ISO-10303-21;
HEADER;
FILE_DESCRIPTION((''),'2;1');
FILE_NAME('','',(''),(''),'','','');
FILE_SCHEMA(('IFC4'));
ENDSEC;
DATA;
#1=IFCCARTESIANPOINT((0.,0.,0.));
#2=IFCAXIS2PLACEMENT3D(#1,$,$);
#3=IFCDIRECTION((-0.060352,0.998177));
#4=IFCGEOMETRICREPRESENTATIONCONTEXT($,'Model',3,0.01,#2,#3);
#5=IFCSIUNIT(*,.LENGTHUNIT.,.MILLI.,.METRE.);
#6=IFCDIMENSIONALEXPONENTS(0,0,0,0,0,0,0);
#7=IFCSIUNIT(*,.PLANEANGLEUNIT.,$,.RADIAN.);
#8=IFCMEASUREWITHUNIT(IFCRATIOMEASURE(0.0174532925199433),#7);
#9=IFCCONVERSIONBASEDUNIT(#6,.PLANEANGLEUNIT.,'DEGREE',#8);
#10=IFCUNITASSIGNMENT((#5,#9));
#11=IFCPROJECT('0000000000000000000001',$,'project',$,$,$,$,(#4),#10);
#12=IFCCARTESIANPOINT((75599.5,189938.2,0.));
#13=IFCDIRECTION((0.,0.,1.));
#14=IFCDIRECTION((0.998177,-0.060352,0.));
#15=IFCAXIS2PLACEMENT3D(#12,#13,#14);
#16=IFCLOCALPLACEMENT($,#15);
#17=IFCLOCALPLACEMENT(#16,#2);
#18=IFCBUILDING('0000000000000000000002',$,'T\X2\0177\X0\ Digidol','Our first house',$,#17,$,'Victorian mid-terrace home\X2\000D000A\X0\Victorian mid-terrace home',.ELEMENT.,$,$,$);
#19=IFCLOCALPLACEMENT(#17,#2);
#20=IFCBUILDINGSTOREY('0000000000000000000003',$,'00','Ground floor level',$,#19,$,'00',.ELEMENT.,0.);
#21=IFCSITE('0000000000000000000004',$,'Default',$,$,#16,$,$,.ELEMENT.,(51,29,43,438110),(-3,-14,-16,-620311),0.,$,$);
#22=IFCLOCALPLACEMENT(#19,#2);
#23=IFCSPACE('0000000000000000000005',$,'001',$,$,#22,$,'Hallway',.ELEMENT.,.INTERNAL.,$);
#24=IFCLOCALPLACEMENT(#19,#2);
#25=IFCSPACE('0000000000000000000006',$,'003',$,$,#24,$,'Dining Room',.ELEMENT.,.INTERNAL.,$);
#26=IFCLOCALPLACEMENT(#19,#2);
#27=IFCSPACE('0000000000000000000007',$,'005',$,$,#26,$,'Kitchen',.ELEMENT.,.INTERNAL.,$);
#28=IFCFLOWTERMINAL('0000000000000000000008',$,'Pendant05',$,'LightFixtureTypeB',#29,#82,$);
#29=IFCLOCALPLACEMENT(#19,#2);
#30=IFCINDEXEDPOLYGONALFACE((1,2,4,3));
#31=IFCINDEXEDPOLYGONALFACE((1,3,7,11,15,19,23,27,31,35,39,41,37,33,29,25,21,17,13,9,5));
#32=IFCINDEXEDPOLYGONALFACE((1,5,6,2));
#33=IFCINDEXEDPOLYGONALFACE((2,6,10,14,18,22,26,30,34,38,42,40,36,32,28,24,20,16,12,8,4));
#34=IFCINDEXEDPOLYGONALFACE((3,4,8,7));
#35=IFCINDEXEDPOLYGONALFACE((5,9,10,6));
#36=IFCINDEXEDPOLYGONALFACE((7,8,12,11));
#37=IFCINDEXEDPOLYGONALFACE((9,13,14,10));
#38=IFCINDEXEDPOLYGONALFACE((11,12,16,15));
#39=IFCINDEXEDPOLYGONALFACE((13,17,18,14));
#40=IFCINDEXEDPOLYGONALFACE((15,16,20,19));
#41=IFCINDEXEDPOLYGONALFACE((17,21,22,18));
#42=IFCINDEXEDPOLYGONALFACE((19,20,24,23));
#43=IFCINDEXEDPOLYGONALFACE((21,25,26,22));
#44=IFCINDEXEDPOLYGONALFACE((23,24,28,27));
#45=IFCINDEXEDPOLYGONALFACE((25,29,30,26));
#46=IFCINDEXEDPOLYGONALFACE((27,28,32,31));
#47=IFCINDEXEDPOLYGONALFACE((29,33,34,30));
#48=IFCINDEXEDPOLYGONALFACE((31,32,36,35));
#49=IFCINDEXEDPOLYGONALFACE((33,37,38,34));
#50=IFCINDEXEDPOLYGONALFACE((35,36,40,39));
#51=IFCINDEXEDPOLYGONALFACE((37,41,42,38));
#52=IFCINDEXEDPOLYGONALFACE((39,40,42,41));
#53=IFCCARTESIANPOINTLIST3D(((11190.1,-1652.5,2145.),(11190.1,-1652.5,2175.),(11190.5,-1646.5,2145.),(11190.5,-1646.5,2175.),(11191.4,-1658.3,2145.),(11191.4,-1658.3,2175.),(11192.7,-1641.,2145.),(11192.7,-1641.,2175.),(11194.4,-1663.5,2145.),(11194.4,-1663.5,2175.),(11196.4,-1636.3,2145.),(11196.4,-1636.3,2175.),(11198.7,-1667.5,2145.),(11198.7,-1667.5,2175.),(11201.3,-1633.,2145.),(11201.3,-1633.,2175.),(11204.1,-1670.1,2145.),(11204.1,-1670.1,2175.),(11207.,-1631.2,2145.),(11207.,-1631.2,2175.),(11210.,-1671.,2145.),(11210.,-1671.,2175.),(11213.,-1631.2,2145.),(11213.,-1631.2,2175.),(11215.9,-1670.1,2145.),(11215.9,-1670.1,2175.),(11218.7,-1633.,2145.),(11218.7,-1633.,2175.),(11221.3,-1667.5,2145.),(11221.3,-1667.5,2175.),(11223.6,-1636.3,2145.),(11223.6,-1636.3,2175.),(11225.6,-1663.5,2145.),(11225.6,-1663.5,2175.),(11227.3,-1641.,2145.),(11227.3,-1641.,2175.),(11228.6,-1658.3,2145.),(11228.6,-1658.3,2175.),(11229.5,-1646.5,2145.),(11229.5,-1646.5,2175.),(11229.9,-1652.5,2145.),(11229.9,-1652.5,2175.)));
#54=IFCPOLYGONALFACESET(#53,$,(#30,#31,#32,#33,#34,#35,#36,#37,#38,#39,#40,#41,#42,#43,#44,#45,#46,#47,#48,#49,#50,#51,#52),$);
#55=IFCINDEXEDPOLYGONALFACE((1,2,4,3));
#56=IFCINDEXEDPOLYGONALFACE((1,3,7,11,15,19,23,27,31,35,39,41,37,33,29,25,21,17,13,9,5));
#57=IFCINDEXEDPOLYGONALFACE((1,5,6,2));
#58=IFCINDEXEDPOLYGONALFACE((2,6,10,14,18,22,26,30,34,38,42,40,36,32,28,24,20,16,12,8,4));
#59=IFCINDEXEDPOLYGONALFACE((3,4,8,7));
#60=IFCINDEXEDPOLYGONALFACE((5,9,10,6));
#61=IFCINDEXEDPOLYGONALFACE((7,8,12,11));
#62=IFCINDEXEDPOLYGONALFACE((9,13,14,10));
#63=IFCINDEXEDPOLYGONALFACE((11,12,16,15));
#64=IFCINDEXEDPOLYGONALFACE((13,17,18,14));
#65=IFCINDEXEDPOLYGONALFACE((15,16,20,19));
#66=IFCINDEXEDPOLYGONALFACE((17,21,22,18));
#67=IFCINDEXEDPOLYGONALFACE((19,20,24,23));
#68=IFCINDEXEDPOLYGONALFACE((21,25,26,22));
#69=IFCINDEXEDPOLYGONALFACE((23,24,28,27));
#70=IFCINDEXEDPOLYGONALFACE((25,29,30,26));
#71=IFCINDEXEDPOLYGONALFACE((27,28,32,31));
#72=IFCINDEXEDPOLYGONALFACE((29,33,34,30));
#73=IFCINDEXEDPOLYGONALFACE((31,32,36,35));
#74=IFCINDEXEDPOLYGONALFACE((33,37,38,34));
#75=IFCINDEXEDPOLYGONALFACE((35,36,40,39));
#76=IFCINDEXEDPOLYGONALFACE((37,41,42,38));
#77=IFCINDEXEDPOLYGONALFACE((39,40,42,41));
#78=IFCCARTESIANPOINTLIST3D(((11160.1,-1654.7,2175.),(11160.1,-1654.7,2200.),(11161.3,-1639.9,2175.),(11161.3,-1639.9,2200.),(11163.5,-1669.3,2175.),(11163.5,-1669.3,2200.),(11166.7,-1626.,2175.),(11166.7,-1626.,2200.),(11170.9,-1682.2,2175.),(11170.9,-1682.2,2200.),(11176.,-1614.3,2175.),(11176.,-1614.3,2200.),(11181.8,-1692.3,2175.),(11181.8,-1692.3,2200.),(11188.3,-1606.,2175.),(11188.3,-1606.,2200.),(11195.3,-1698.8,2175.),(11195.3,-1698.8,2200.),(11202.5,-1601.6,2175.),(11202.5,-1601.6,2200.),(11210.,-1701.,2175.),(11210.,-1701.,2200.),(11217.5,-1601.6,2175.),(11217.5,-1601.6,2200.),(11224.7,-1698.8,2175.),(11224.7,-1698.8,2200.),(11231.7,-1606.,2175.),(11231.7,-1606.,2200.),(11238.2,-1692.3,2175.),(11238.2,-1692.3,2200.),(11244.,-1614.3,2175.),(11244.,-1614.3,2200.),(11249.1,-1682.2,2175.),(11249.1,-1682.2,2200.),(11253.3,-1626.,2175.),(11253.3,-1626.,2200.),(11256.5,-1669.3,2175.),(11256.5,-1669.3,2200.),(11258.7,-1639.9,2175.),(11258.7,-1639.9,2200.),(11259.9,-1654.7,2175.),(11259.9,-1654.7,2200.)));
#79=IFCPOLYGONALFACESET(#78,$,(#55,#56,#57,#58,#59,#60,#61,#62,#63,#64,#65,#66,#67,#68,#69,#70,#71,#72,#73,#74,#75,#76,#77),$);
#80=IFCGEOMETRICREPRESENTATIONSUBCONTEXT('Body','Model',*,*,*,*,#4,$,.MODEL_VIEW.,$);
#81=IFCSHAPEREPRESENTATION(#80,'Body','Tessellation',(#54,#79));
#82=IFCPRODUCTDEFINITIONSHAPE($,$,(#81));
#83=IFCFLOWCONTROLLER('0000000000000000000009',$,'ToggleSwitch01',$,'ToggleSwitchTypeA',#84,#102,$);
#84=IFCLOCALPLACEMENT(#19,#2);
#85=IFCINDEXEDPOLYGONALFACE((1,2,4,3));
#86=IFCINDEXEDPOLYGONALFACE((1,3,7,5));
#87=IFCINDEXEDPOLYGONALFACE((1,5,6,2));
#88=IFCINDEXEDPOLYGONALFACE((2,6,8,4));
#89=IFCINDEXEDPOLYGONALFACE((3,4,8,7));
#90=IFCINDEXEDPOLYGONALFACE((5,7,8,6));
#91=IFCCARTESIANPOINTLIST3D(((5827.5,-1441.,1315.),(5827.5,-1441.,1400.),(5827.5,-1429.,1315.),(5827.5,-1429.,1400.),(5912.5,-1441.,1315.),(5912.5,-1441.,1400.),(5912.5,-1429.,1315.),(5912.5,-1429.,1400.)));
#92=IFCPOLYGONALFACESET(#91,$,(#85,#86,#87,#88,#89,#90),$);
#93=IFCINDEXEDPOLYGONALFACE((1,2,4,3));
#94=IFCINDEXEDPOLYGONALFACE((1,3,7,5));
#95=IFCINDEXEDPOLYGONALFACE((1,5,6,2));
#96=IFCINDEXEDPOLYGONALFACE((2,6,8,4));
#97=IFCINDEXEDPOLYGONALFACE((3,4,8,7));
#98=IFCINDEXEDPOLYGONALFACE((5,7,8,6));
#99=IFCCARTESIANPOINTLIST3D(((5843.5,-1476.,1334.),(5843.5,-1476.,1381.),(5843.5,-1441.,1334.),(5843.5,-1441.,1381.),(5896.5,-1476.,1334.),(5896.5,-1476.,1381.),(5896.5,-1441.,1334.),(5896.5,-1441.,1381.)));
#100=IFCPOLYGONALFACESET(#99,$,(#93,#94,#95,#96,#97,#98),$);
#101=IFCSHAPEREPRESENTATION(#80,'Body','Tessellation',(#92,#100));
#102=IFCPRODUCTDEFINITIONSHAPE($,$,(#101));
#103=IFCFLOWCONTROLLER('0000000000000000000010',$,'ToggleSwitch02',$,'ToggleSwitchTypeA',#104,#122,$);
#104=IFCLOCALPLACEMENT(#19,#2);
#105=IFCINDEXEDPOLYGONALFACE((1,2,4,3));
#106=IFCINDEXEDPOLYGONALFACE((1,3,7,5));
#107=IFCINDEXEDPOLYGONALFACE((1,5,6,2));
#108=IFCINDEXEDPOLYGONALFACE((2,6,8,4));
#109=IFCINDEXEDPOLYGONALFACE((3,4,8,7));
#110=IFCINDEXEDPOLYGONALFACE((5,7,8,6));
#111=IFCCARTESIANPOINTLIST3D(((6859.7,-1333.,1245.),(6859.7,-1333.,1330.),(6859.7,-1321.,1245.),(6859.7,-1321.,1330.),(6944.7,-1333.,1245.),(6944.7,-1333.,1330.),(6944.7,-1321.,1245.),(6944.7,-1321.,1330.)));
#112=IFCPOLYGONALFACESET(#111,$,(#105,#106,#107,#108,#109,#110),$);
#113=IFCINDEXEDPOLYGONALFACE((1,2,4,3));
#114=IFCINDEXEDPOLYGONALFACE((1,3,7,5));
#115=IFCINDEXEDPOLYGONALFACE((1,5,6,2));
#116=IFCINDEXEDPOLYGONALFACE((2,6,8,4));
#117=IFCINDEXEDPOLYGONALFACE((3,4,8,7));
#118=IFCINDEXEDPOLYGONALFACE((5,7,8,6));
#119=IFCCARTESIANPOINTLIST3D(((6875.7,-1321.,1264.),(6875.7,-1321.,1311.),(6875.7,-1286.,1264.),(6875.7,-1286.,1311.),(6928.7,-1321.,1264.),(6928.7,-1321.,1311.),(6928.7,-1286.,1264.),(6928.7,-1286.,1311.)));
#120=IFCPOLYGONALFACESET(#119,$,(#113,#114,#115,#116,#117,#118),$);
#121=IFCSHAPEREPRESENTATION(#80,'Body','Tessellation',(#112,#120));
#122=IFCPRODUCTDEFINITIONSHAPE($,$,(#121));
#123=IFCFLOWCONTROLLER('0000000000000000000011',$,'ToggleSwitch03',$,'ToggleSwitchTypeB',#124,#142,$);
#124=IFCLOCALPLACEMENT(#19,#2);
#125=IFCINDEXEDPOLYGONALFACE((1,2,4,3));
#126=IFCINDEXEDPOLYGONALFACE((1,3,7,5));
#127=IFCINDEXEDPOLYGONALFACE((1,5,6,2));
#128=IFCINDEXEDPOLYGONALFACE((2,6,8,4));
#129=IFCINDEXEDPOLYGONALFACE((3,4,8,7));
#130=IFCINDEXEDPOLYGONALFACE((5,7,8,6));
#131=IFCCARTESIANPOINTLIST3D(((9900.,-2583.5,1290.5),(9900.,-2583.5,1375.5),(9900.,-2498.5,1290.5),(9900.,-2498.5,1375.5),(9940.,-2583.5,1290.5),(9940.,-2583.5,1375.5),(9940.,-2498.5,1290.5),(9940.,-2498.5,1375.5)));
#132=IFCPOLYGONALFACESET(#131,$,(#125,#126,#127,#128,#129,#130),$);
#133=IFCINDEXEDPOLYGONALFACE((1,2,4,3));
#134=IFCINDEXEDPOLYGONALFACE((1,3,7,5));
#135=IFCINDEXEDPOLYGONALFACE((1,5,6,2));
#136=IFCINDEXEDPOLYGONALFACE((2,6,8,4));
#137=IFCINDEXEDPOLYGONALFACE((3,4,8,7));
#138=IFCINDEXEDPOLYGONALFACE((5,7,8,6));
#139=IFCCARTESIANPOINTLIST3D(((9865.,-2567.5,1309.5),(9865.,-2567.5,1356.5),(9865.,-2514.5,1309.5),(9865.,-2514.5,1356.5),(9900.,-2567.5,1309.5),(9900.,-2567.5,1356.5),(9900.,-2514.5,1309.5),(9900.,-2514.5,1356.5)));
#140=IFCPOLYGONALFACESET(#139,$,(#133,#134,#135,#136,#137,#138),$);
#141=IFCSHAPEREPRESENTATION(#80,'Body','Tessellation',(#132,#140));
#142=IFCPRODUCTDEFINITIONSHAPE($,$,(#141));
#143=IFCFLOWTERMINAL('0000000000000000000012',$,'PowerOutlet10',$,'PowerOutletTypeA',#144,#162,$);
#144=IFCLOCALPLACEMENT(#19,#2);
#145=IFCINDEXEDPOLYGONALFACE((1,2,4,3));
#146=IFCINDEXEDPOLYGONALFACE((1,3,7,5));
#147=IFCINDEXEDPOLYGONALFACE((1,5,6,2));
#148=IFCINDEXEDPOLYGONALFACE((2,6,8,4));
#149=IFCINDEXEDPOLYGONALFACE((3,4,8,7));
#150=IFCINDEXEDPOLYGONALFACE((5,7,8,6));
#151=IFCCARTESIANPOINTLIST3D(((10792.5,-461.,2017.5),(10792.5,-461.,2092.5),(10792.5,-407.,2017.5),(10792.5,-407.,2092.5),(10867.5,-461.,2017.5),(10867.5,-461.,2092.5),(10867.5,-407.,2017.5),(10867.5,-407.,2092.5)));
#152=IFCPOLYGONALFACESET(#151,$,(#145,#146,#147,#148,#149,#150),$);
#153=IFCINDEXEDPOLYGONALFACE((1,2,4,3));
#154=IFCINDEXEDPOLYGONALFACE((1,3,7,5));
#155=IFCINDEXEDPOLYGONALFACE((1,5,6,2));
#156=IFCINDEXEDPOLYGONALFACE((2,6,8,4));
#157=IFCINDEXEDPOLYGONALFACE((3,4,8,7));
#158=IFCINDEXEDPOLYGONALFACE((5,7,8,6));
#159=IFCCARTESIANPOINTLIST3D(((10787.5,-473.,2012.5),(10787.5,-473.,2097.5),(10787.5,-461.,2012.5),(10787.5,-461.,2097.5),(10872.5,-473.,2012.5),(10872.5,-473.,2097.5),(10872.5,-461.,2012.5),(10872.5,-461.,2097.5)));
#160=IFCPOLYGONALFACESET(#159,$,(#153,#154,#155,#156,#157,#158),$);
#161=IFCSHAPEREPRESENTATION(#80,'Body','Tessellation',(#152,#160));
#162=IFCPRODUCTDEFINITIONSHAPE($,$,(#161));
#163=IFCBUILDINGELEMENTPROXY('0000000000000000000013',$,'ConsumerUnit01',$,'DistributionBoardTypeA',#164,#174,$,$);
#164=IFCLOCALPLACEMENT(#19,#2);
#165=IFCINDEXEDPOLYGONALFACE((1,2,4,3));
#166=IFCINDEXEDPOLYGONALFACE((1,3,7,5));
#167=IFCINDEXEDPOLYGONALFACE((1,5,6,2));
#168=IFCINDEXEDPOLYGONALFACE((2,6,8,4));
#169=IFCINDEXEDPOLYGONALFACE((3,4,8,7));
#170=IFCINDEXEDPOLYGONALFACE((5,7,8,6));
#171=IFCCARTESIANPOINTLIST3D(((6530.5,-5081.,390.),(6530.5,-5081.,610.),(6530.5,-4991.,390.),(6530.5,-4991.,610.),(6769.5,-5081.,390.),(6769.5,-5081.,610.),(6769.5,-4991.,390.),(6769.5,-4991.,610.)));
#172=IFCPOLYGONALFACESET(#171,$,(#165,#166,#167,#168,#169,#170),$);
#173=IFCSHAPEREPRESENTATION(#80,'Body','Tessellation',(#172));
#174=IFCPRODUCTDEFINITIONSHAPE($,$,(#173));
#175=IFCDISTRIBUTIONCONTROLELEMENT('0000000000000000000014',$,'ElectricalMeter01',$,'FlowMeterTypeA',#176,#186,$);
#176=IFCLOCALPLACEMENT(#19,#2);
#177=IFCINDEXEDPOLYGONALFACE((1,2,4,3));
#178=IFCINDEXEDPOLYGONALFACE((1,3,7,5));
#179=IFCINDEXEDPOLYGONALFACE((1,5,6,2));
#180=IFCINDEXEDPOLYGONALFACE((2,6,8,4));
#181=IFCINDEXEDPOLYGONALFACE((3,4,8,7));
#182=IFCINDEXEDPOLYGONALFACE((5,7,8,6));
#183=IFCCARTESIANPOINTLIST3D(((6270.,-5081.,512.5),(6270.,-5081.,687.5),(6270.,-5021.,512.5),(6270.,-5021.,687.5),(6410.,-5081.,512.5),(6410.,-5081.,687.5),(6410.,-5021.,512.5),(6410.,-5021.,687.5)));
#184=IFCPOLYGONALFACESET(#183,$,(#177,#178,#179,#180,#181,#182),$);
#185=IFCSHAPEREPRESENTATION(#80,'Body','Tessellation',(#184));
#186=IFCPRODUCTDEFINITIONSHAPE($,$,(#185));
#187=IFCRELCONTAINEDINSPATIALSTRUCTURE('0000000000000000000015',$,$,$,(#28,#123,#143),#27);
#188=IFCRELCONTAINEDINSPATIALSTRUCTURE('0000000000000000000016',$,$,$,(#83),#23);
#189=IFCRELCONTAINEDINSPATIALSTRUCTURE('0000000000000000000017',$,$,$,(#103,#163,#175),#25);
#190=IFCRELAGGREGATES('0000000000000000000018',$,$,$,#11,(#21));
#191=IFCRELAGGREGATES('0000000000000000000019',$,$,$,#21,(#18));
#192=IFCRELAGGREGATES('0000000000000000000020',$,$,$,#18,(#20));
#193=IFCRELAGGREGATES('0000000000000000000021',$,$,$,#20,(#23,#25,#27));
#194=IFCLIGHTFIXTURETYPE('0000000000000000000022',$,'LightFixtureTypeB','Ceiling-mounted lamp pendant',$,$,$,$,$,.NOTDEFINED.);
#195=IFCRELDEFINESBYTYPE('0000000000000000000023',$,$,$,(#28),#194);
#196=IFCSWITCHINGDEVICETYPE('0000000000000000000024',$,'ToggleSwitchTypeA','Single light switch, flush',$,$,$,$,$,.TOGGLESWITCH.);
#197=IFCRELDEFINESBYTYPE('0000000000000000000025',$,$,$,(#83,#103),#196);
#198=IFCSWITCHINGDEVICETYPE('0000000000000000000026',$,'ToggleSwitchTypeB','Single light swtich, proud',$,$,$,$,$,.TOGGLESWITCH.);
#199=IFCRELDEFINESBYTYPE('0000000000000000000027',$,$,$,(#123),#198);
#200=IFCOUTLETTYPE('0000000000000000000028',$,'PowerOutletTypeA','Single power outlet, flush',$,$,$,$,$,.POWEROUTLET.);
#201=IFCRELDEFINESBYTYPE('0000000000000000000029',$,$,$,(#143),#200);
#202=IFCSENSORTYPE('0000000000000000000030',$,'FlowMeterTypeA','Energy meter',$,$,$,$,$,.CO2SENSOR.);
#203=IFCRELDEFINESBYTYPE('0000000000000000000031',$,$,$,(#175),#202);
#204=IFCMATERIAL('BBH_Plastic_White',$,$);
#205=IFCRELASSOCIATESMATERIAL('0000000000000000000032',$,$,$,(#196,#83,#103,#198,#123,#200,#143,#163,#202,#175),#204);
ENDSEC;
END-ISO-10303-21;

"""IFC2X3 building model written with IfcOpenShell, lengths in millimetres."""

from ifc_helpers import new_model, entity, si_unit, converted_unit, direction, frame, frame_2d, origin, origin_2d_with_axis, place, context, subcontext, project, spatial, rectangle, circle, extrude, source, transform, mapped, material, type_object, type_shapes, element, save


model = new_model("IFC2X3")

# Units and contexts
model_context = context("Model", 3, precision=0.01, world=origin(), true_north=direction((-0.060352, 0.998177)))
body_context = subcontext(model_context, "Body", "Model", "MODEL_VIEW")
ifc_project = project(units=[si_unit("LENGTHUNIT", "METRE", prefix="MILLI"), converted_unit("PLANEANGLEUNIT", "DEGREE", entity("IfcRatioMeasure", 0.0174532925199433), si_unit("PLANEANGLEUNIT", "RADIAN"), dimensions=[0, 0, 0, 0, 0, 0, 0])], contexts=[model_context])

# Site, building, storey
site_placement = place(None, frame((75599.5, 189938.2, 0.0), z_axis=(0.0, 0.0, 1.0), x_axis=(0.998177, -0.060352, 0.0)))
site = spatial("IfcSite", under=ifc_project, at=site_placement, Name="Default", CompositionType="ELEMENT", RefLatitude=(51, 29, 43, 438110), RefLongitude=(-3, -14, -16, -620311), RefElevation=0.0)
building_placement = place(site_placement, origin())
building = spatial("IfcBuilding", under=site, at=building_placement, Name="Tŷ Digidol", Description="Our first house", LongName="Victorian mid-terrace home\r\nVictorian mid-terrace home", CompositionType="ELEMENT")
storey_placement = place(building_placement, origin())
storey = spatial("IfcBuildingStorey", under=building, at=storey_placement, Name="00", Description="Ground floor level", LongName="00", CompositionType="ELEMENT", Elevation=0.0)

# Shared definitions
ifc_material_1 = material(Name="BBH_Plastic_White")

# Shared definitions
space_1_placement = place(storey_placement, origin())
space_1 = spatial("IfcSpace", under=storey, at=space_1_placement, Name="001", LongName="Hallway", CompositionType="ELEMENT", InteriorOrExteriorSpace="INTERNAL")

# Shared definitions
space_2_placement = place(storey_placement, origin())
space_2 = spatial("IfcSpace", under=storey, at=space_2_placement, Name="003", LongName="Dining Room", CompositionType="ELEMENT", InteriorOrExteriorSpace="INTERNAL")

# Shared definitions
space_3_placement = place(storey_placement, origin())
space_3 = spatial("IfcSpace", under=storey, at=space_3_placement, Name="005", LongName="Kitchen", CompositionType="ELEMENT", InteriorOrExteriorSpace="INTERNAL")

# Flow terminal
light_fixture_type_1 = type_object("IfcLightFixtureType", Name="LightFixtureTypeB", Description="Ceiling-mounted lamp pendant", PredefinedType="NOTDEFINED")
shared_shape_1 = source(origin(), body_context, "Body", "SweptSolid", [
    extrude(circle(Radius=20.0, at=frame_2d((0.0, 0.0), x_axis=(1.0, 0.0))), frame((0.0, 0.0, 25.0)), (0.0, 0.0, 1.0), 30.0),
    extrude(circle(Radius=50.0, at=frame_2d((0.0, 0.0), x_axis=(1.0, 0.0))), origin(), (0.0, 0.0, 1.0), 25.0),
])
type_shapes(light_fixture_type_1, [shared_shape_1])
flow_terminal_1_placement = place(space_3_placement, frame((11210.0, -1651.0, 2200.0), z_axis=(0.0, 0.0, -1.0), x_axis=(0.0, -1.0, 0.0)))
element("IfcFlowTerminal", 1, at=flow_terminal_1_placement, inside=space_3, type_object=light_fixture_type_1, Name="Pendant05", ObjectType="LightFixtureTypeB", context=body_context, shape_type="MappedRepresentation", body=[
    mapped(shared_shape_1, transform((0.0, 0.0, 0.0), scale=1.0)),
])

# Flow controllers
switching_device_type_1 = type_object("IfcSwitchingDeviceType", Name="ToggleSwitchTypeA", Description="Single light switch, flush", PredefinedType="TOGGLESWITCH", material=ifc_material_1)
shared_shape_2 = source(origin(), body_context, "Body", "SweptSolid", [
    extrude(rectangle(XDim=85.0, YDim=85.0, at=origin_2d_with_axis()), frame((0.0, -42.5, 0.0), z_axis=(0.0, 0.0, 1.0), x_axis=(0.0, 1.0, 0.0)), (0.0, 0.0, 1.0), 12.0),
    extrude(rectangle(XDim=47.0, YDim=53.0, at=origin_2d_with_axis()), frame((0.0, -42.5, -35.0), z_axis=(0.0, 0.0, 1.0), x_axis=(0.0, 1.0, 0.0)), (0.0, 0.0, 1.0), 35.0),
])
type_shapes(switching_device_type_1, [shared_shape_2])
flow_controller_1_placement = place(space_1_placement, frame((5870.0, -1441.0, 1400.0), z_axis=(0.0, 1.0, 0.0), x_axis=(-1.0, 0.0, 0.0)))
element("IfcFlowController", 2, at=flow_controller_1_placement, inside=space_1, type_object=switching_device_type_1, material=ifc_material_1, Name="ToggleSwitch01", ObjectType="ToggleSwitchTypeA", context=body_context, shape_type="MappedRepresentation", body=[
    mapped(shared_shape_2, transform((0.0, 0.0, 0.0), scale=1.0)),
])
flow_controller_2_placement = place(space_2_placement, frame((6902.2, -1321.0, 1330.0), z_axis=(0.0, -1.0, 0.0), x_axis=(1.0, 0.0, 0.0)))
element("IfcFlowController", 3, at=flow_controller_2_placement, inside=space_2, type_object=switching_device_type_1, material=ifc_material_1, Name="ToggleSwitch02", ObjectType="ToggleSwitchTypeA", context=body_context, shape_type="MappedRepresentation", body=[
    mapped(shared_shape_2, transform((0.0, 0.0, 0.0), scale=1.0)),
])
switching_device_type_2 = type_object("IfcSwitchingDeviceType", Name="ToggleSwitchTypeB", Description="Single light swtich, proud", PredefinedType="TOGGLESWITCH", material=ifc_material_1)
shared_shape_3 = source(origin(), body_context, "Body", "SweptSolid", [
    extrude(rectangle(XDim=85.0, YDim=85.0, at=origin_2d_with_axis()), frame((0.0, -42.5, 0.0), z_axis=(0.0, 0.0, 1.0), x_axis=(0.0, 1.0, 0.0)), (0.0, 0.0, 1.0), 40.0),
    extrude(rectangle(XDim=47.0, YDim=53.0, at=origin_2d_with_axis()), frame((0.0, -42.5, -35.0), z_axis=(0.0, 0.0, 1.0), x_axis=(0.0, 1.0, 0.0)), (0.0, 0.0, 1.0), 35.0),
])
type_shapes(switching_device_type_2, [shared_shape_3])
flow_controller_3_placement = place(space_3_placement, frame((9900.0, -2541.0, 1290.5), z_axis=(1.0, 0.0, 0.0), x_axis=(0.0, -1.0, 0.0)))
element("IfcFlowController", 4, at=flow_controller_3_placement, inside=space_3, type_object=switching_device_type_2, material=ifc_material_1, Name="ToggleSwitch03", ObjectType="ToggleSwitchTypeB", context=body_context, shape_type="MappedRepresentation", body=[
    mapped(shared_shape_3, transform((0.0, 0.0, 0.0), scale=1.0)),
])

# Flow terminal
outlet_type_1 = type_object("IfcOutletType", Name="PowerOutletTypeA", Description="Single power outlet, flush", PredefinedType="POWEROUTLET", material=ifc_material_1)
shared_shape_4 = source(origin(), body_context, "Body", "SweptSolid", [
    extrude(rectangle(XDim=75.0, YDim=75.0, at=origin_2d_with_axis()), frame((0.0, 0.0, -54.0), z_axis=(0.0, 0.0, 1.0), x_axis=(-1.0, 0.0, 0.0)), (0.0, 0.0, 1.0), 54.0),
    extrude(rectangle(XDim=85.0, YDim=85.0, at=origin_2d_with_axis()), frame((0.0, 0.0, 0.0), z_axis=(0.0, 0.0, 1.0), x_axis=(-1.0, 0.0, 0.0)), (0.0, 0.0, 1.0), 12.0),
])
type_shapes(outlet_type_1, [shared_shape_4])
flow_terminal_2_placement = place(space_3_placement, frame((10830.0, -461.0, 2055.0), z_axis=(0.0, -1.0, 0.0), x_axis=(1.0, 0.0, 0.0)))
element("IfcFlowTerminal", 5, at=flow_terminal_2_placement, inside=space_3, type_object=outlet_type_1, material=ifc_material_1, Name="PowerOutlet10", ObjectType="PowerOutletTypeA", context=body_context, shape_type="MappedRepresentation", body=[
    mapped(shared_shape_4, transform((0.0, 0.0, 0.0), scale=1.0)),
])

# Electric distribution point
shared_shape_5 = source(origin(), body_context, "Body", "SweptSolid", [
    extrude(rectangle(XDim=239.0, YDim=220.0, at=origin_2d_with_axis()), frame((0.0, 0.0, 0.0), z_axis=(0.0, 0.0, 1.0), x_axis=(-1.0, 0.0, 0.0)), (0.0, 0.0, 1.0), 90.0),
])
electric_distribution_point_placement = place(space_2_placement, frame((6650.0, -5081.0, 500.0), z_axis=(0.0, 1.0, 0.0), x_axis=(-1.0, 0.0, 0.0)))
element("IfcElectricDistributionPoint", 6, at=electric_distribution_point_placement, inside=space_2, material=ifc_material_1, Name="ConsumerUnit01", ObjectType="DistributionBoardTypeA", context=body_context, shape_type="MappedRepresentation", body=[
    mapped(shared_shape_5, transform((0.0, 0.0, 0.0), scale=1.0)),
])

# Distribution control element
sensor_type_1 = type_object("IfcSensorType", Name="FlowMeterTypeA", Description="Energy meter", PredefinedType="CO2SENSOR", material=ifc_material_1)
shared_shape_6 = source(origin(), body_context, "Body", "SweptSolid", [
    extrude(rectangle(XDim=140.0, YDim=175.0, at=origin_2d_with_axis()), frame((0.0, 0.0, 0.0), z_axis=(0.0, 0.0, 1.0), x_axis=(-1.0, 0.0, 0.0)), (0.0, 0.0, 1.0), 60.0),
])
type_shapes(sensor_type_1, [shared_shape_6])
distribution_control_element_1_placement = place(space_2_placement, frame((6340.0, -5081.0, 600.0), z_axis=(0.0, 1.0, 0.0), x_axis=(1.0, 0.0, 0.0)))
element("IfcDistributionControlElement", 7, at=distribution_control_element_1_placement, inside=space_2, type_object=sensor_type_1, material=ifc_material_1, Name="ElectricalMeter01", ObjectType="FlowMeterTypeA", context=body_context, shape_type="MappedRepresentation", body=[
    mapped(shared_shape_6, transform((0.0, 0.0, 0.0), scale=1.0)),
])

save(model, "model.ifc")
